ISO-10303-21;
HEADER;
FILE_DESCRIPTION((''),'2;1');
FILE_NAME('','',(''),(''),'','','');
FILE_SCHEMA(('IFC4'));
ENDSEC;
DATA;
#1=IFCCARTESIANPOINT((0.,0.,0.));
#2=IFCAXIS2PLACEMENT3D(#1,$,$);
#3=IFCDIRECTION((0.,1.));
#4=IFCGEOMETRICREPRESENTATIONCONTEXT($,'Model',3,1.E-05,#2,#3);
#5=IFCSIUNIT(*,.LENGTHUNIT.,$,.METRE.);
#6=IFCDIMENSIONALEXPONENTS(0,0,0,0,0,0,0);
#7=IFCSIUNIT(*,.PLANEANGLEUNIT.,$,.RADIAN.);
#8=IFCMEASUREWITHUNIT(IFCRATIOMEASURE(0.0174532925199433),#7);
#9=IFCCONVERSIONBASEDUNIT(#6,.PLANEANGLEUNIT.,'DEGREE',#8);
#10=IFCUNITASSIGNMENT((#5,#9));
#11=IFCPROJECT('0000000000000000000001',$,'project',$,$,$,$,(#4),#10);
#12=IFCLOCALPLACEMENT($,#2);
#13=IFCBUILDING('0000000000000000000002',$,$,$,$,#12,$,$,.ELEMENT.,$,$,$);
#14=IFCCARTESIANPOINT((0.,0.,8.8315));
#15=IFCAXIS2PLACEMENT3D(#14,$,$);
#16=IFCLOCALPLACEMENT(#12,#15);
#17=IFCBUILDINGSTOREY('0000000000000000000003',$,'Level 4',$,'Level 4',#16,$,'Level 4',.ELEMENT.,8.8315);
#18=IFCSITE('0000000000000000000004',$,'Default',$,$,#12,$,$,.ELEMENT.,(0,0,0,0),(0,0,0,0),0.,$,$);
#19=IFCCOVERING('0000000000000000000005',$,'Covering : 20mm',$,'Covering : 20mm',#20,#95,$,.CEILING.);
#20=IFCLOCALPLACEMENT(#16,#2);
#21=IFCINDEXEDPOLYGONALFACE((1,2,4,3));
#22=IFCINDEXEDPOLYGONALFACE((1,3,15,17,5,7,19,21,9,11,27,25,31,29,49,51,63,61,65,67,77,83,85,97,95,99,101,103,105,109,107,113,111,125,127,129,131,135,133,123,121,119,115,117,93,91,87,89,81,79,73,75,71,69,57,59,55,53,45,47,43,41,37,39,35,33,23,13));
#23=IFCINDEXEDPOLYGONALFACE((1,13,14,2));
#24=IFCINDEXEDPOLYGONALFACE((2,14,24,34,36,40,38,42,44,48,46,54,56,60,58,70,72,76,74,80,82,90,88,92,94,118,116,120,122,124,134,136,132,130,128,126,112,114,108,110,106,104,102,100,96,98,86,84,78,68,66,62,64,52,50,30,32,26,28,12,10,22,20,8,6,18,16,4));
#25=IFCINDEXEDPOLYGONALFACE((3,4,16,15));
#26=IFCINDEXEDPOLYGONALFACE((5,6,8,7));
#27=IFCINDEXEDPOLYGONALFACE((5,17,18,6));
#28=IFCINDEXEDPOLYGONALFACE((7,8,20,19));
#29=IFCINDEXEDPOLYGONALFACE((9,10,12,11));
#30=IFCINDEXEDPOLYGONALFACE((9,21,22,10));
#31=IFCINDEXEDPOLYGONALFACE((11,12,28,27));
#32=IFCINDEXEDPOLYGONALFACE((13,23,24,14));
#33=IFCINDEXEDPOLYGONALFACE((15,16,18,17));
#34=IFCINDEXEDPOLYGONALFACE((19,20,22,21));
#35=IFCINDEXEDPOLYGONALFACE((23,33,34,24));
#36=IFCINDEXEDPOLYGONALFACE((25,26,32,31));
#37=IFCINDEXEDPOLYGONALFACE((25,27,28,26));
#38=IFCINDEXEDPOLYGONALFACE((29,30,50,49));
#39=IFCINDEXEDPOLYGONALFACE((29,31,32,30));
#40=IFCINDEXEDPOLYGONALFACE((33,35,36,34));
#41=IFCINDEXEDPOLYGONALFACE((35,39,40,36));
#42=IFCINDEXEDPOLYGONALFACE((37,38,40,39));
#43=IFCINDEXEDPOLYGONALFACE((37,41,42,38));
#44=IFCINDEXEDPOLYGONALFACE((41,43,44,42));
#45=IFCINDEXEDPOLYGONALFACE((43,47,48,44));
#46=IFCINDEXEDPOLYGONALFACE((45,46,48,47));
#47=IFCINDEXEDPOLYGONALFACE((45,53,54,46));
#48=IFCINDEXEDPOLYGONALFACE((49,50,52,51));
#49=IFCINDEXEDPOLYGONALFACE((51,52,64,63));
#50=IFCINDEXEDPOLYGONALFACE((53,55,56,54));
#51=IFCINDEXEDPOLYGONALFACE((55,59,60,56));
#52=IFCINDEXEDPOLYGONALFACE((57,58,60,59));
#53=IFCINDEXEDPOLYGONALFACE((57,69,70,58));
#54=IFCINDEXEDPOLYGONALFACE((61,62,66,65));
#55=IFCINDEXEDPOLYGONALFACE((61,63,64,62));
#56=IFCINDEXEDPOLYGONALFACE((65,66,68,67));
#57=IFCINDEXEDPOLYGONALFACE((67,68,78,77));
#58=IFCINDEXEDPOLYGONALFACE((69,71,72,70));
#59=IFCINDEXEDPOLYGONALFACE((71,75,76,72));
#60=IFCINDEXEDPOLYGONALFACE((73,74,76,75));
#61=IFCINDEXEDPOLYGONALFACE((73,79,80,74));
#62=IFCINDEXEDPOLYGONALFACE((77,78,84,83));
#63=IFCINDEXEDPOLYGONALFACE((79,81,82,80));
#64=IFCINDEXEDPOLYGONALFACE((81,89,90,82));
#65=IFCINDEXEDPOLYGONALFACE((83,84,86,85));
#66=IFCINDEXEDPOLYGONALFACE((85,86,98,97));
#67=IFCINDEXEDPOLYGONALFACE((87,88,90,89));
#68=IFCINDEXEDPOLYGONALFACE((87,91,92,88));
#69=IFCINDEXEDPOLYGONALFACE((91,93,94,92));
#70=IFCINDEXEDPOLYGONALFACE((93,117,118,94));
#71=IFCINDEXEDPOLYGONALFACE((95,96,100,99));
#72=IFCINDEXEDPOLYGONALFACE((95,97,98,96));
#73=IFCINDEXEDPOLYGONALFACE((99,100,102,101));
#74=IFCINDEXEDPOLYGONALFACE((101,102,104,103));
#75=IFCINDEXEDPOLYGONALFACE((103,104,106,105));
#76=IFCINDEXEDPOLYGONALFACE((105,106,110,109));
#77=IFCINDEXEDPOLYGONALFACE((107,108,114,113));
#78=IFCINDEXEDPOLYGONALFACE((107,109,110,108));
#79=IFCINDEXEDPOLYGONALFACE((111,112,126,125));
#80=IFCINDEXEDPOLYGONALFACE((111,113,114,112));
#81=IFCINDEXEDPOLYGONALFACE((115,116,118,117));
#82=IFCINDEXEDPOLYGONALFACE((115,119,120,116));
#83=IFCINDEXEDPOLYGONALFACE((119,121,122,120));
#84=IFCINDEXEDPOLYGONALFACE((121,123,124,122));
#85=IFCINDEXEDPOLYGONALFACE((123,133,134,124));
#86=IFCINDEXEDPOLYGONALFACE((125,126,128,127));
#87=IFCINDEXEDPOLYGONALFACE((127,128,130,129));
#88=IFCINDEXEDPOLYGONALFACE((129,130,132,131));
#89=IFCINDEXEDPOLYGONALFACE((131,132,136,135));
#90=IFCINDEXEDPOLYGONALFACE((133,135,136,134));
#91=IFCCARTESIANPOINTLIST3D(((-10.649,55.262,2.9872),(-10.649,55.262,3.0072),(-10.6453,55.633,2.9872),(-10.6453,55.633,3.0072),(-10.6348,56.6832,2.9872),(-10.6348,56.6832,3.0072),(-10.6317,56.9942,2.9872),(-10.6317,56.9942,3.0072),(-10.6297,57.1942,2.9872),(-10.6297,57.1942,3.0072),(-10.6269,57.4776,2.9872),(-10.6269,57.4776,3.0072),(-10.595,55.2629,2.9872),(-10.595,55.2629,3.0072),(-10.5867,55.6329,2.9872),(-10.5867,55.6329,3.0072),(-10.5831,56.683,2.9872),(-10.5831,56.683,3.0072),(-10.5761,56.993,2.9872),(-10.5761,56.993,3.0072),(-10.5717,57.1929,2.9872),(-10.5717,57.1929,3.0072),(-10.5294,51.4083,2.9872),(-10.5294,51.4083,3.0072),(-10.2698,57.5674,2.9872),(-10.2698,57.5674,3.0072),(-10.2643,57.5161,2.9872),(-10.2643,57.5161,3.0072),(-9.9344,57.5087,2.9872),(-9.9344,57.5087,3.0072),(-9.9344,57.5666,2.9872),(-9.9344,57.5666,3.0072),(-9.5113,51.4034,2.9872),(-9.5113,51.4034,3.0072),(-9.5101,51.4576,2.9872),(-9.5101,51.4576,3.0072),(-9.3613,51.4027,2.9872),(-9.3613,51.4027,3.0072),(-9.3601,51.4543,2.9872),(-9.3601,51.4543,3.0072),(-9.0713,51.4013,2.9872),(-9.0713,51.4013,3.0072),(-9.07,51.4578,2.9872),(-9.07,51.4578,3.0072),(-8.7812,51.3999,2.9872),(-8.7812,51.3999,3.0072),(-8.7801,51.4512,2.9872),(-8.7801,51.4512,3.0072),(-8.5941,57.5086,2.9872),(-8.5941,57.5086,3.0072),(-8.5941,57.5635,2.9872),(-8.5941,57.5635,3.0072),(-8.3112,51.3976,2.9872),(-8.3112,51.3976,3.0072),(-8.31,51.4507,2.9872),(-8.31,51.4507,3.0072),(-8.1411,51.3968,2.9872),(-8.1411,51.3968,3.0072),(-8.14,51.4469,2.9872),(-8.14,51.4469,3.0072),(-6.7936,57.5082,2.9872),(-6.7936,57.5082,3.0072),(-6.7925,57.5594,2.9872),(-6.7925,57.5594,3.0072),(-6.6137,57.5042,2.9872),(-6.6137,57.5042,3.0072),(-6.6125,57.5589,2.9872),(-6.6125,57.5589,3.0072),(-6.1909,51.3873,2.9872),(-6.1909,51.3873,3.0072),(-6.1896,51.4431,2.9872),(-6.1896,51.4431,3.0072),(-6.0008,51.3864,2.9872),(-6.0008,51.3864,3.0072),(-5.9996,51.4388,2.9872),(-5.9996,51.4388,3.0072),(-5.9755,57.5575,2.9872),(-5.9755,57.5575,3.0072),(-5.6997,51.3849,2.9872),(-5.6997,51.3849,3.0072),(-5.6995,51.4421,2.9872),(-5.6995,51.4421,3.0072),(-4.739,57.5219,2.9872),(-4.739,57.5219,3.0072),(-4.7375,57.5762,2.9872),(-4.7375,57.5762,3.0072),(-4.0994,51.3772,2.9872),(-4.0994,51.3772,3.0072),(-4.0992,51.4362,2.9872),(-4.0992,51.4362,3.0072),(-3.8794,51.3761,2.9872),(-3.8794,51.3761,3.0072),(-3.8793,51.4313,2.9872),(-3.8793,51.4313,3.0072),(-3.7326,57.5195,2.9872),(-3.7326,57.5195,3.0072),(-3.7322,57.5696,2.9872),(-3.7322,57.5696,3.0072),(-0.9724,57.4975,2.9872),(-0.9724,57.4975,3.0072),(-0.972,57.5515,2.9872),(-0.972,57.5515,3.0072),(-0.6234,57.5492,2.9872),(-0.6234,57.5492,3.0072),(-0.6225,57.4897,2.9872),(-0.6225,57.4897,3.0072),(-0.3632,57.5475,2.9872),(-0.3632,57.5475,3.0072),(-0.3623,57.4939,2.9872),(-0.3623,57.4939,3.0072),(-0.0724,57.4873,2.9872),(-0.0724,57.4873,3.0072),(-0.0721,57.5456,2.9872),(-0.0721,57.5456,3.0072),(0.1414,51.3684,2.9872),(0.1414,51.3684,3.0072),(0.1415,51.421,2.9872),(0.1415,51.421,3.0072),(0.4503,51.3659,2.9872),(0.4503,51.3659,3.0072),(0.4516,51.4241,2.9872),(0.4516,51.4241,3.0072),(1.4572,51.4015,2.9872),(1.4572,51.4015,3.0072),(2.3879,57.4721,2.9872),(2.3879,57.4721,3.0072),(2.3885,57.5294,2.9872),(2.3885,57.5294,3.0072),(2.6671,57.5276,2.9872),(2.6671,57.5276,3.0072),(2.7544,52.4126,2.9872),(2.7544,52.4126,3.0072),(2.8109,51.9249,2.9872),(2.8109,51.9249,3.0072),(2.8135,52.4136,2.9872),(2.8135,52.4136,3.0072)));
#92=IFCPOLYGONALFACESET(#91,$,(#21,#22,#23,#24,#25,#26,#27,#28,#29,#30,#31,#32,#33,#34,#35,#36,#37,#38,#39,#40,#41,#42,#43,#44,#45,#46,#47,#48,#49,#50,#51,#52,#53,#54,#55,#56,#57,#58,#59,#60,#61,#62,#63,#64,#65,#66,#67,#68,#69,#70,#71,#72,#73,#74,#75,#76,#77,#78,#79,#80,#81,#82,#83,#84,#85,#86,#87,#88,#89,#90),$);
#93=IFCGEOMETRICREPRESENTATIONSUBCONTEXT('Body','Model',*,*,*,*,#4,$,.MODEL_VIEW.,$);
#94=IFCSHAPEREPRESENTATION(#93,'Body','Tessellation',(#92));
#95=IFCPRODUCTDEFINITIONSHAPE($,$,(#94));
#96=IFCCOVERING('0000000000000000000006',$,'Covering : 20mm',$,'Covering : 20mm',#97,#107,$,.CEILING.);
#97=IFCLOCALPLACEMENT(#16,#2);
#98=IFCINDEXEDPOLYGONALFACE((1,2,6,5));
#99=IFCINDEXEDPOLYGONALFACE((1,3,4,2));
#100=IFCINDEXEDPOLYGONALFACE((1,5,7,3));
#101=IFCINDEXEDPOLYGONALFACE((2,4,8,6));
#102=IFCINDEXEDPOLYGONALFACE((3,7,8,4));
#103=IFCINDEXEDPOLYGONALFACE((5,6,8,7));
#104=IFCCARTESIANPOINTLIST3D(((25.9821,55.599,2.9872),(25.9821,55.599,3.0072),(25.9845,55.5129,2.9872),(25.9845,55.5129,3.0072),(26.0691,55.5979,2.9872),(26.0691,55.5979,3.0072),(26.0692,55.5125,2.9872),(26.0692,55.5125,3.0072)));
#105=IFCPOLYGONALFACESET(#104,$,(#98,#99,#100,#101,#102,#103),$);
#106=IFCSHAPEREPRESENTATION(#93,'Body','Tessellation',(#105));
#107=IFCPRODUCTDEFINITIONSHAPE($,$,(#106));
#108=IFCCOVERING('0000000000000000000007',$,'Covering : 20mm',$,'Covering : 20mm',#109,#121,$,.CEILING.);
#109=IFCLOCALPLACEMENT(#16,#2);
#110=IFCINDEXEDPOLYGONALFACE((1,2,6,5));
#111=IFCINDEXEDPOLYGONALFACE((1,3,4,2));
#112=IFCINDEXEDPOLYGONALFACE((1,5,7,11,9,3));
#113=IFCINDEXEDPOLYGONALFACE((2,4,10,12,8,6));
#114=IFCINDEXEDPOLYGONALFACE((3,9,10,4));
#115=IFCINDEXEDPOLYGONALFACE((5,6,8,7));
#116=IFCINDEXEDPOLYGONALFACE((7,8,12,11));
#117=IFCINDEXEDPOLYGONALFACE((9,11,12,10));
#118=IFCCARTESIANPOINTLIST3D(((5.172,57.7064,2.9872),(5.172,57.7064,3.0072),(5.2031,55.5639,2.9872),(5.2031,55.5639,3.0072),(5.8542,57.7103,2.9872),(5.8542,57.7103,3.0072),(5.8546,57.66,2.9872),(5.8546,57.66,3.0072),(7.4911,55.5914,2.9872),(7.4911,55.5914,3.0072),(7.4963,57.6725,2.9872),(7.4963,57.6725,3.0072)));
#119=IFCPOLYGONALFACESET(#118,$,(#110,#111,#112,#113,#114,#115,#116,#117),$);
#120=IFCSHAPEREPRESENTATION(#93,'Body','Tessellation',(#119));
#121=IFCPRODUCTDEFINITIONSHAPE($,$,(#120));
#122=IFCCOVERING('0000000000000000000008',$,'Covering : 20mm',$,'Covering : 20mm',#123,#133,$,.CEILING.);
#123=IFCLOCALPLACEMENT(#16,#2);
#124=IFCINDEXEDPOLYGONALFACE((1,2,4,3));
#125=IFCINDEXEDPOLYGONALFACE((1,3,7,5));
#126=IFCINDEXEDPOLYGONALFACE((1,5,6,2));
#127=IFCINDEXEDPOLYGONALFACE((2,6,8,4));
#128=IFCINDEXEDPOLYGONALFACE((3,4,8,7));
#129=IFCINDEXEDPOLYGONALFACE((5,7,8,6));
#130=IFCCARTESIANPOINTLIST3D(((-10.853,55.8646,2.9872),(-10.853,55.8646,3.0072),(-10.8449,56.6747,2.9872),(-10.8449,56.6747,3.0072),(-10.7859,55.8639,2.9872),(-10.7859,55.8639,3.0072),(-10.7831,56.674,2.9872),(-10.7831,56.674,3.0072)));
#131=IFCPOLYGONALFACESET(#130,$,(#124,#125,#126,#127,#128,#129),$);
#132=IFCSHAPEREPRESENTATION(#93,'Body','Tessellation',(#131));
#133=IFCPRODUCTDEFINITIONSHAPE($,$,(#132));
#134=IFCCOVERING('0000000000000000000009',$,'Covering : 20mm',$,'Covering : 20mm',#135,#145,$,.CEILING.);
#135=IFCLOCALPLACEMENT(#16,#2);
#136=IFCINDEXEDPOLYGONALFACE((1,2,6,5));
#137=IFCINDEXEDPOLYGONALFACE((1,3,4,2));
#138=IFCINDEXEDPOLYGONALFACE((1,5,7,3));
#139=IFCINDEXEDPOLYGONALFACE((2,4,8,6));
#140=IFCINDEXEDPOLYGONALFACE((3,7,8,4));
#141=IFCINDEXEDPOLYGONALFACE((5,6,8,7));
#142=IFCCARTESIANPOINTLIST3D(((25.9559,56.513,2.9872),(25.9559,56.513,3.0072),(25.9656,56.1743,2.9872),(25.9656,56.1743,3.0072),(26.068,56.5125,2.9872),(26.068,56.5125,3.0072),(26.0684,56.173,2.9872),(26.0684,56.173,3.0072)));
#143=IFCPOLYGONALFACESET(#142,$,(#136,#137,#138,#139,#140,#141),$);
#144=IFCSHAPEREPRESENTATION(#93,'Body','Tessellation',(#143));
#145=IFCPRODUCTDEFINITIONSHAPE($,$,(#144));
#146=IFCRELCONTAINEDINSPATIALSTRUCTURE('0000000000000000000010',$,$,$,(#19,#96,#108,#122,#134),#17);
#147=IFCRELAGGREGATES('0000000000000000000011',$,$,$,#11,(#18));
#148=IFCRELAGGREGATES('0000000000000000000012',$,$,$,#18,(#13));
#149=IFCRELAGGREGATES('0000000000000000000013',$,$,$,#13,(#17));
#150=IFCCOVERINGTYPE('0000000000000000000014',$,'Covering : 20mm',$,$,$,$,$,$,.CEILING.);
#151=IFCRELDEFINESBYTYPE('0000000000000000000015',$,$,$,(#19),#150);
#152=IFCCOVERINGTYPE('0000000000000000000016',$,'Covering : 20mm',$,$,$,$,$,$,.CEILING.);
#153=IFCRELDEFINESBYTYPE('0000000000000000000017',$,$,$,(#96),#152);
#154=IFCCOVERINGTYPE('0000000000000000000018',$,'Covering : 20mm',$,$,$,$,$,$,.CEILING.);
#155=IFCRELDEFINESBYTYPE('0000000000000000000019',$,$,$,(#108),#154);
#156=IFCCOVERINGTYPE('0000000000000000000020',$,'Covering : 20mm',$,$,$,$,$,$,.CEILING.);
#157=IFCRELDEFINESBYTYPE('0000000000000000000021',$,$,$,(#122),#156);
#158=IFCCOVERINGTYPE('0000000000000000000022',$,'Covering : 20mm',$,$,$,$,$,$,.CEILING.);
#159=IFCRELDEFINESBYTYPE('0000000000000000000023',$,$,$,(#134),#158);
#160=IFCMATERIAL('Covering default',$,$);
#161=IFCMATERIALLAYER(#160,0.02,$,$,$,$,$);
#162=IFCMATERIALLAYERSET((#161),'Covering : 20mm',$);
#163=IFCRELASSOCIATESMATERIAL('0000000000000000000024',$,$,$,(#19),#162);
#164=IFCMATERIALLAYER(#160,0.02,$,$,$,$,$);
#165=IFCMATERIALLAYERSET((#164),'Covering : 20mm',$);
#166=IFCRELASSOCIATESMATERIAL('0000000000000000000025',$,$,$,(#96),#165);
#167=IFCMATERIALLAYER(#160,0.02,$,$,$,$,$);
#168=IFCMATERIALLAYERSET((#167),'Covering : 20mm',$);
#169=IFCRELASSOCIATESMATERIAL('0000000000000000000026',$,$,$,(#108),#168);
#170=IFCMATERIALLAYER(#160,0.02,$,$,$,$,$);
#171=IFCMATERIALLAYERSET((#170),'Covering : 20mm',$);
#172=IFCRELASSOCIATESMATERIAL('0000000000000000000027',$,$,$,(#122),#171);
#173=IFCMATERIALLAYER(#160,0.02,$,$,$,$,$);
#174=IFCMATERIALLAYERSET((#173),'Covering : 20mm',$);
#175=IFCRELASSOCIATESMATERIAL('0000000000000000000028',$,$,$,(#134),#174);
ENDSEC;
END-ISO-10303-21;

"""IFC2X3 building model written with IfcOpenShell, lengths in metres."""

from ifc_helpers import new_model, entity, si_unit, converted_unit, direction, frame, origin, origin_with_axes, place, context, subcontext, project, spatial, polyline, outline, extrude, material, layer, layer_set, layer_usage, type_object, element, save


model = new_model("IFC2X3")

# Units and contexts
model_context = context("Model", 3, precision=1e-05, world=origin(), true_north=direction((0.0, 1.0)))
body_context = subcontext(model_context, "Body", "Model", "MODEL_VIEW")
ifc_project = project(units=[si_unit("LENGTHUNIT", "METRE"), converted_unit("PLANEANGLEUNIT", "DEGREE", entity("IfcRatioMeasure", 0.0174532925199433), si_unit("PLANEANGLEUNIT", "RADIAN"), dimensions=[0, 0, 0, 0, 0, 0, 0])], contexts=[model_context])

# Site, building, storey
placement = place(None, origin())
site = spatial("IfcSite", under=ifc_project, at=placement, Name="Default", CompositionType="ELEMENT", RefLatitude=(0, 0, 0, 0), RefLongitude=(0, 0, 0, 0), RefElevation=0.0)
building = spatial("IfcBuilding", under=site, at=placement, CompositionType="ELEMENT")
storey_placement = place(placement, frame((0.0, 0.0, 8.8315)))
storey = spatial("IfcBuildingStorey", under=building, at=storey_placement, Name="Level 4", ObjectType="Level 4", LongName="Level 4", CompositionType="ELEMENT", Elevation=8.8315)

# Coverings
ifc_material_1 = material(Name="Covering default")
ifc_layer_1 = layer(ifc_material_1, 0.02)
ifc_layer_set_1 = layer_set([ifc_layer_1], Name="Covering : 20mm")
ifc_layer_usage_1 = layer_usage(ifc_layer_set_1, "AXIS3", "POSITIVE", 0.0)
covering_type_1 = type_object("IfcCoveringType", Name="Covering : 20mm", PredefinedType="CEILING")
covering_1_placement = place(placement, frame((0.0, 0.0, 11.8187)))
element("IfcCovering", 1, at=covering_1_placement, inside=storey, type_object=covering_type_1, material=ifc_layer_usage_1, Name="Covering : 20mm", ObjectType="Covering : 20mm", PredefinedType="CEILING", context=body_context, shape_type="SweptSolid", body=[
    extrude(outline(polyline([(-10.6453, 55.633), (-10.5867, 55.6329), (-10.5831, 56.683), (-10.6348, 56.6832), (-10.6317, 56.9942), (-10.5761, 56.993), (-10.5717, 57.1929), (-10.6297, 57.1942), (-10.6269, 57.4776), (-10.2643, 57.5161), (-10.2698, 57.5674), (-9.9344, 57.5666), (-9.9344, 57.5087), (-8.5941, 57.5086), (-8.5941, 57.5635), (-6.7925, 57.5594), (-6.7936, 57.5082), (-6.6137, 57.5042), (-6.6125, 57.5589), (-5.9755, 57.5575), (-4.739, 57.5219), (-4.7375, 57.5762), (-3.7322, 57.5696), (-3.7326, 57.5195), (-0.9724, 57.4975), (-0.972, 57.5515), (-0.6234, 57.5492), (-0.6225, 57.4897), (-0.3623, 57.4939), (-0.3632, 57.5475), (-0.0721, 57.5456), (-0.0724, 57.4873), (2.3879, 57.4721), (2.3885, 57.5294), (2.6671, 57.5276), (2.7544, 52.4126), (2.8135, 52.4136), (2.8109, 51.9249), (1.4572, 51.4015), (0.4516, 51.4241), (0.4503, 51.3659), (0.1414, 51.3684), (0.1415, 51.421), (-3.8793, 51.4313), (-3.8794, 51.3761), (-4.0994, 51.3772), (-4.0992, 51.4362), (-5.6995, 51.4421), (-5.6997, 51.3849), (-6.0008, 51.3864), (-5.9996, 51.4388), (-6.1896, 51.4431), (-6.1909, 51.3873), (-8.1411, 51.3968), (-8.14, 51.4469), (-8.31, 51.4507), (-8.3112, 51.3976), (-8.7812, 51.3999), (-8.7801, 51.4512), (-9.07, 51.4578), (-9.0713, 51.4013), (-9.3613, 51.4027), (-9.3601, 51.4543), (-9.5101, 51.4576), (-9.5113, 51.4034), (-10.5294, 51.4083), (-10.595, 55.2629), (-10.649, 55.262), (-10.6453, 55.633)])), origin_with_axes(), (0.0, 0.0, 1.0), 0.02),
])
ifc_layer_2 = layer(ifc_material_1, 0.02)
ifc_layer_set_2 = layer_set([ifc_layer_2], Name="Covering : 20mm")
ifc_layer_usage_2 = layer_usage(ifc_layer_set_2, "AXIS3", "POSITIVE", 0.0)
covering_type_2 = type_object("IfcCoveringType", Name="Covering : 20mm", PredefinedType="CEILING")
covering_2_placement = place(placement, frame((0.0, 0.0, 11.8187)))
element("IfcCovering", 2, at=covering_2_placement, inside=storey, type_object=covering_type_2, material=ifc_layer_usage_2, Name="Covering : 20mm", ObjectType="Covering : 20mm", PredefinedType="CEILING", context=body_context, shape_type="SweptSolid", body=[
    extrude(outline(polyline([(25.9821, 55.599), (26.0691, 55.5979), (26.0692, 55.5125), (25.9845, 55.5129), (25.9821, 55.599)])), origin_with_axes(), (0.0, 0.0, 1.0), 0.02),
])
ifc_layer_3 = layer(ifc_material_1, 0.02)
ifc_layer_set_3 = layer_set([ifc_layer_3], Name="Covering : 20mm")
ifc_layer_usage_3 = layer_usage(ifc_layer_set_3, "AXIS3", "POSITIVE", 0.0)
covering_type_3 = type_object("IfcCoveringType", Name="Covering : 20mm", PredefinedType="CEILING")
covering_3_placement = place(placement, frame((0.0, 0.0, 11.8187)))
element("IfcCovering", 3, at=covering_3_placement, inside=storey, type_object=covering_type_3, material=ifc_layer_usage_3, Name="Covering : 20mm", ObjectType="Covering : 20mm", PredefinedType="CEILING", context=body_context, shape_type="SweptSolid", body=[
    extrude(outline(polyline([(5.2031, 55.5639), (7.4911, 55.5914), (7.4963, 57.6725), (5.8546, 57.66), (5.8542, 57.7103), (5.172, 57.7064), (5.2031, 55.5639)])), origin_with_axes(), (0.0, 0.0, 1.0), 0.02),
])
ifc_layer_4 = layer(ifc_material_1, 0.02)
ifc_layer_set_4 = layer_set([ifc_layer_4], Name="Covering : 20mm")
ifc_layer_usage_4 = layer_usage(ifc_layer_set_4, "AXIS3", "POSITIVE", 0.0)
covering_type_4 = type_object("IfcCoveringType", Name="Covering : 20mm", PredefinedType="CEILING")
covering_4_placement = place(placement, frame((0.0, 0.0, 11.8187)))
element("IfcCovering", 4, at=covering_4_placement, inside=storey, type_object=covering_type_4, material=ifc_layer_usage_4, Name="Covering : 20mm", ObjectType="Covering : 20mm", PredefinedType="CEILING", context=body_context, shape_type="SweptSolid", body=[
    extrude(outline(polyline([(-10.8449, 56.6747), (-10.7831, 56.674), (-10.7859, 55.8639), (-10.853, 55.8646), (-10.8449, 56.6747)])), origin_with_axes(), (0.0, 0.0, 1.0), 0.02),
])
ifc_layer_5 = layer(ifc_material_1, 0.02)
ifc_layer_set_5 = layer_set([ifc_layer_5], Name="Covering : 20mm")
ifc_layer_usage_5 = layer_usage(ifc_layer_set_5, "AXIS3", "POSITIVE", 0.0)
covering_type_5 = type_object("IfcCoveringType", Name="Covering : 20mm", PredefinedType="CEILING")
covering_5_placement = place(placement, frame((0.0, 0.0, 11.8187)))
element("IfcCovering", 5, at=covering_5_placement, inside=storey, type_object=covering_type_5, material=ifc_layer_usage_5, Name="Covering : 20mm", ObjectType="Covering : 20mm", PredefinedType="CEILING", context=body_context, shape_type="SweptSolid", body=[
    extrude(outline(polyline([(25.9656, 56.1743), (26.0684, 56.173), (26.068, 56.5125), (25.9559, 56.513), (25.9656, 56.1743)])), origin_with_axes(), (0.0, 0.0, 1.0), 0.02),
])

save(model, "model.ifc")
